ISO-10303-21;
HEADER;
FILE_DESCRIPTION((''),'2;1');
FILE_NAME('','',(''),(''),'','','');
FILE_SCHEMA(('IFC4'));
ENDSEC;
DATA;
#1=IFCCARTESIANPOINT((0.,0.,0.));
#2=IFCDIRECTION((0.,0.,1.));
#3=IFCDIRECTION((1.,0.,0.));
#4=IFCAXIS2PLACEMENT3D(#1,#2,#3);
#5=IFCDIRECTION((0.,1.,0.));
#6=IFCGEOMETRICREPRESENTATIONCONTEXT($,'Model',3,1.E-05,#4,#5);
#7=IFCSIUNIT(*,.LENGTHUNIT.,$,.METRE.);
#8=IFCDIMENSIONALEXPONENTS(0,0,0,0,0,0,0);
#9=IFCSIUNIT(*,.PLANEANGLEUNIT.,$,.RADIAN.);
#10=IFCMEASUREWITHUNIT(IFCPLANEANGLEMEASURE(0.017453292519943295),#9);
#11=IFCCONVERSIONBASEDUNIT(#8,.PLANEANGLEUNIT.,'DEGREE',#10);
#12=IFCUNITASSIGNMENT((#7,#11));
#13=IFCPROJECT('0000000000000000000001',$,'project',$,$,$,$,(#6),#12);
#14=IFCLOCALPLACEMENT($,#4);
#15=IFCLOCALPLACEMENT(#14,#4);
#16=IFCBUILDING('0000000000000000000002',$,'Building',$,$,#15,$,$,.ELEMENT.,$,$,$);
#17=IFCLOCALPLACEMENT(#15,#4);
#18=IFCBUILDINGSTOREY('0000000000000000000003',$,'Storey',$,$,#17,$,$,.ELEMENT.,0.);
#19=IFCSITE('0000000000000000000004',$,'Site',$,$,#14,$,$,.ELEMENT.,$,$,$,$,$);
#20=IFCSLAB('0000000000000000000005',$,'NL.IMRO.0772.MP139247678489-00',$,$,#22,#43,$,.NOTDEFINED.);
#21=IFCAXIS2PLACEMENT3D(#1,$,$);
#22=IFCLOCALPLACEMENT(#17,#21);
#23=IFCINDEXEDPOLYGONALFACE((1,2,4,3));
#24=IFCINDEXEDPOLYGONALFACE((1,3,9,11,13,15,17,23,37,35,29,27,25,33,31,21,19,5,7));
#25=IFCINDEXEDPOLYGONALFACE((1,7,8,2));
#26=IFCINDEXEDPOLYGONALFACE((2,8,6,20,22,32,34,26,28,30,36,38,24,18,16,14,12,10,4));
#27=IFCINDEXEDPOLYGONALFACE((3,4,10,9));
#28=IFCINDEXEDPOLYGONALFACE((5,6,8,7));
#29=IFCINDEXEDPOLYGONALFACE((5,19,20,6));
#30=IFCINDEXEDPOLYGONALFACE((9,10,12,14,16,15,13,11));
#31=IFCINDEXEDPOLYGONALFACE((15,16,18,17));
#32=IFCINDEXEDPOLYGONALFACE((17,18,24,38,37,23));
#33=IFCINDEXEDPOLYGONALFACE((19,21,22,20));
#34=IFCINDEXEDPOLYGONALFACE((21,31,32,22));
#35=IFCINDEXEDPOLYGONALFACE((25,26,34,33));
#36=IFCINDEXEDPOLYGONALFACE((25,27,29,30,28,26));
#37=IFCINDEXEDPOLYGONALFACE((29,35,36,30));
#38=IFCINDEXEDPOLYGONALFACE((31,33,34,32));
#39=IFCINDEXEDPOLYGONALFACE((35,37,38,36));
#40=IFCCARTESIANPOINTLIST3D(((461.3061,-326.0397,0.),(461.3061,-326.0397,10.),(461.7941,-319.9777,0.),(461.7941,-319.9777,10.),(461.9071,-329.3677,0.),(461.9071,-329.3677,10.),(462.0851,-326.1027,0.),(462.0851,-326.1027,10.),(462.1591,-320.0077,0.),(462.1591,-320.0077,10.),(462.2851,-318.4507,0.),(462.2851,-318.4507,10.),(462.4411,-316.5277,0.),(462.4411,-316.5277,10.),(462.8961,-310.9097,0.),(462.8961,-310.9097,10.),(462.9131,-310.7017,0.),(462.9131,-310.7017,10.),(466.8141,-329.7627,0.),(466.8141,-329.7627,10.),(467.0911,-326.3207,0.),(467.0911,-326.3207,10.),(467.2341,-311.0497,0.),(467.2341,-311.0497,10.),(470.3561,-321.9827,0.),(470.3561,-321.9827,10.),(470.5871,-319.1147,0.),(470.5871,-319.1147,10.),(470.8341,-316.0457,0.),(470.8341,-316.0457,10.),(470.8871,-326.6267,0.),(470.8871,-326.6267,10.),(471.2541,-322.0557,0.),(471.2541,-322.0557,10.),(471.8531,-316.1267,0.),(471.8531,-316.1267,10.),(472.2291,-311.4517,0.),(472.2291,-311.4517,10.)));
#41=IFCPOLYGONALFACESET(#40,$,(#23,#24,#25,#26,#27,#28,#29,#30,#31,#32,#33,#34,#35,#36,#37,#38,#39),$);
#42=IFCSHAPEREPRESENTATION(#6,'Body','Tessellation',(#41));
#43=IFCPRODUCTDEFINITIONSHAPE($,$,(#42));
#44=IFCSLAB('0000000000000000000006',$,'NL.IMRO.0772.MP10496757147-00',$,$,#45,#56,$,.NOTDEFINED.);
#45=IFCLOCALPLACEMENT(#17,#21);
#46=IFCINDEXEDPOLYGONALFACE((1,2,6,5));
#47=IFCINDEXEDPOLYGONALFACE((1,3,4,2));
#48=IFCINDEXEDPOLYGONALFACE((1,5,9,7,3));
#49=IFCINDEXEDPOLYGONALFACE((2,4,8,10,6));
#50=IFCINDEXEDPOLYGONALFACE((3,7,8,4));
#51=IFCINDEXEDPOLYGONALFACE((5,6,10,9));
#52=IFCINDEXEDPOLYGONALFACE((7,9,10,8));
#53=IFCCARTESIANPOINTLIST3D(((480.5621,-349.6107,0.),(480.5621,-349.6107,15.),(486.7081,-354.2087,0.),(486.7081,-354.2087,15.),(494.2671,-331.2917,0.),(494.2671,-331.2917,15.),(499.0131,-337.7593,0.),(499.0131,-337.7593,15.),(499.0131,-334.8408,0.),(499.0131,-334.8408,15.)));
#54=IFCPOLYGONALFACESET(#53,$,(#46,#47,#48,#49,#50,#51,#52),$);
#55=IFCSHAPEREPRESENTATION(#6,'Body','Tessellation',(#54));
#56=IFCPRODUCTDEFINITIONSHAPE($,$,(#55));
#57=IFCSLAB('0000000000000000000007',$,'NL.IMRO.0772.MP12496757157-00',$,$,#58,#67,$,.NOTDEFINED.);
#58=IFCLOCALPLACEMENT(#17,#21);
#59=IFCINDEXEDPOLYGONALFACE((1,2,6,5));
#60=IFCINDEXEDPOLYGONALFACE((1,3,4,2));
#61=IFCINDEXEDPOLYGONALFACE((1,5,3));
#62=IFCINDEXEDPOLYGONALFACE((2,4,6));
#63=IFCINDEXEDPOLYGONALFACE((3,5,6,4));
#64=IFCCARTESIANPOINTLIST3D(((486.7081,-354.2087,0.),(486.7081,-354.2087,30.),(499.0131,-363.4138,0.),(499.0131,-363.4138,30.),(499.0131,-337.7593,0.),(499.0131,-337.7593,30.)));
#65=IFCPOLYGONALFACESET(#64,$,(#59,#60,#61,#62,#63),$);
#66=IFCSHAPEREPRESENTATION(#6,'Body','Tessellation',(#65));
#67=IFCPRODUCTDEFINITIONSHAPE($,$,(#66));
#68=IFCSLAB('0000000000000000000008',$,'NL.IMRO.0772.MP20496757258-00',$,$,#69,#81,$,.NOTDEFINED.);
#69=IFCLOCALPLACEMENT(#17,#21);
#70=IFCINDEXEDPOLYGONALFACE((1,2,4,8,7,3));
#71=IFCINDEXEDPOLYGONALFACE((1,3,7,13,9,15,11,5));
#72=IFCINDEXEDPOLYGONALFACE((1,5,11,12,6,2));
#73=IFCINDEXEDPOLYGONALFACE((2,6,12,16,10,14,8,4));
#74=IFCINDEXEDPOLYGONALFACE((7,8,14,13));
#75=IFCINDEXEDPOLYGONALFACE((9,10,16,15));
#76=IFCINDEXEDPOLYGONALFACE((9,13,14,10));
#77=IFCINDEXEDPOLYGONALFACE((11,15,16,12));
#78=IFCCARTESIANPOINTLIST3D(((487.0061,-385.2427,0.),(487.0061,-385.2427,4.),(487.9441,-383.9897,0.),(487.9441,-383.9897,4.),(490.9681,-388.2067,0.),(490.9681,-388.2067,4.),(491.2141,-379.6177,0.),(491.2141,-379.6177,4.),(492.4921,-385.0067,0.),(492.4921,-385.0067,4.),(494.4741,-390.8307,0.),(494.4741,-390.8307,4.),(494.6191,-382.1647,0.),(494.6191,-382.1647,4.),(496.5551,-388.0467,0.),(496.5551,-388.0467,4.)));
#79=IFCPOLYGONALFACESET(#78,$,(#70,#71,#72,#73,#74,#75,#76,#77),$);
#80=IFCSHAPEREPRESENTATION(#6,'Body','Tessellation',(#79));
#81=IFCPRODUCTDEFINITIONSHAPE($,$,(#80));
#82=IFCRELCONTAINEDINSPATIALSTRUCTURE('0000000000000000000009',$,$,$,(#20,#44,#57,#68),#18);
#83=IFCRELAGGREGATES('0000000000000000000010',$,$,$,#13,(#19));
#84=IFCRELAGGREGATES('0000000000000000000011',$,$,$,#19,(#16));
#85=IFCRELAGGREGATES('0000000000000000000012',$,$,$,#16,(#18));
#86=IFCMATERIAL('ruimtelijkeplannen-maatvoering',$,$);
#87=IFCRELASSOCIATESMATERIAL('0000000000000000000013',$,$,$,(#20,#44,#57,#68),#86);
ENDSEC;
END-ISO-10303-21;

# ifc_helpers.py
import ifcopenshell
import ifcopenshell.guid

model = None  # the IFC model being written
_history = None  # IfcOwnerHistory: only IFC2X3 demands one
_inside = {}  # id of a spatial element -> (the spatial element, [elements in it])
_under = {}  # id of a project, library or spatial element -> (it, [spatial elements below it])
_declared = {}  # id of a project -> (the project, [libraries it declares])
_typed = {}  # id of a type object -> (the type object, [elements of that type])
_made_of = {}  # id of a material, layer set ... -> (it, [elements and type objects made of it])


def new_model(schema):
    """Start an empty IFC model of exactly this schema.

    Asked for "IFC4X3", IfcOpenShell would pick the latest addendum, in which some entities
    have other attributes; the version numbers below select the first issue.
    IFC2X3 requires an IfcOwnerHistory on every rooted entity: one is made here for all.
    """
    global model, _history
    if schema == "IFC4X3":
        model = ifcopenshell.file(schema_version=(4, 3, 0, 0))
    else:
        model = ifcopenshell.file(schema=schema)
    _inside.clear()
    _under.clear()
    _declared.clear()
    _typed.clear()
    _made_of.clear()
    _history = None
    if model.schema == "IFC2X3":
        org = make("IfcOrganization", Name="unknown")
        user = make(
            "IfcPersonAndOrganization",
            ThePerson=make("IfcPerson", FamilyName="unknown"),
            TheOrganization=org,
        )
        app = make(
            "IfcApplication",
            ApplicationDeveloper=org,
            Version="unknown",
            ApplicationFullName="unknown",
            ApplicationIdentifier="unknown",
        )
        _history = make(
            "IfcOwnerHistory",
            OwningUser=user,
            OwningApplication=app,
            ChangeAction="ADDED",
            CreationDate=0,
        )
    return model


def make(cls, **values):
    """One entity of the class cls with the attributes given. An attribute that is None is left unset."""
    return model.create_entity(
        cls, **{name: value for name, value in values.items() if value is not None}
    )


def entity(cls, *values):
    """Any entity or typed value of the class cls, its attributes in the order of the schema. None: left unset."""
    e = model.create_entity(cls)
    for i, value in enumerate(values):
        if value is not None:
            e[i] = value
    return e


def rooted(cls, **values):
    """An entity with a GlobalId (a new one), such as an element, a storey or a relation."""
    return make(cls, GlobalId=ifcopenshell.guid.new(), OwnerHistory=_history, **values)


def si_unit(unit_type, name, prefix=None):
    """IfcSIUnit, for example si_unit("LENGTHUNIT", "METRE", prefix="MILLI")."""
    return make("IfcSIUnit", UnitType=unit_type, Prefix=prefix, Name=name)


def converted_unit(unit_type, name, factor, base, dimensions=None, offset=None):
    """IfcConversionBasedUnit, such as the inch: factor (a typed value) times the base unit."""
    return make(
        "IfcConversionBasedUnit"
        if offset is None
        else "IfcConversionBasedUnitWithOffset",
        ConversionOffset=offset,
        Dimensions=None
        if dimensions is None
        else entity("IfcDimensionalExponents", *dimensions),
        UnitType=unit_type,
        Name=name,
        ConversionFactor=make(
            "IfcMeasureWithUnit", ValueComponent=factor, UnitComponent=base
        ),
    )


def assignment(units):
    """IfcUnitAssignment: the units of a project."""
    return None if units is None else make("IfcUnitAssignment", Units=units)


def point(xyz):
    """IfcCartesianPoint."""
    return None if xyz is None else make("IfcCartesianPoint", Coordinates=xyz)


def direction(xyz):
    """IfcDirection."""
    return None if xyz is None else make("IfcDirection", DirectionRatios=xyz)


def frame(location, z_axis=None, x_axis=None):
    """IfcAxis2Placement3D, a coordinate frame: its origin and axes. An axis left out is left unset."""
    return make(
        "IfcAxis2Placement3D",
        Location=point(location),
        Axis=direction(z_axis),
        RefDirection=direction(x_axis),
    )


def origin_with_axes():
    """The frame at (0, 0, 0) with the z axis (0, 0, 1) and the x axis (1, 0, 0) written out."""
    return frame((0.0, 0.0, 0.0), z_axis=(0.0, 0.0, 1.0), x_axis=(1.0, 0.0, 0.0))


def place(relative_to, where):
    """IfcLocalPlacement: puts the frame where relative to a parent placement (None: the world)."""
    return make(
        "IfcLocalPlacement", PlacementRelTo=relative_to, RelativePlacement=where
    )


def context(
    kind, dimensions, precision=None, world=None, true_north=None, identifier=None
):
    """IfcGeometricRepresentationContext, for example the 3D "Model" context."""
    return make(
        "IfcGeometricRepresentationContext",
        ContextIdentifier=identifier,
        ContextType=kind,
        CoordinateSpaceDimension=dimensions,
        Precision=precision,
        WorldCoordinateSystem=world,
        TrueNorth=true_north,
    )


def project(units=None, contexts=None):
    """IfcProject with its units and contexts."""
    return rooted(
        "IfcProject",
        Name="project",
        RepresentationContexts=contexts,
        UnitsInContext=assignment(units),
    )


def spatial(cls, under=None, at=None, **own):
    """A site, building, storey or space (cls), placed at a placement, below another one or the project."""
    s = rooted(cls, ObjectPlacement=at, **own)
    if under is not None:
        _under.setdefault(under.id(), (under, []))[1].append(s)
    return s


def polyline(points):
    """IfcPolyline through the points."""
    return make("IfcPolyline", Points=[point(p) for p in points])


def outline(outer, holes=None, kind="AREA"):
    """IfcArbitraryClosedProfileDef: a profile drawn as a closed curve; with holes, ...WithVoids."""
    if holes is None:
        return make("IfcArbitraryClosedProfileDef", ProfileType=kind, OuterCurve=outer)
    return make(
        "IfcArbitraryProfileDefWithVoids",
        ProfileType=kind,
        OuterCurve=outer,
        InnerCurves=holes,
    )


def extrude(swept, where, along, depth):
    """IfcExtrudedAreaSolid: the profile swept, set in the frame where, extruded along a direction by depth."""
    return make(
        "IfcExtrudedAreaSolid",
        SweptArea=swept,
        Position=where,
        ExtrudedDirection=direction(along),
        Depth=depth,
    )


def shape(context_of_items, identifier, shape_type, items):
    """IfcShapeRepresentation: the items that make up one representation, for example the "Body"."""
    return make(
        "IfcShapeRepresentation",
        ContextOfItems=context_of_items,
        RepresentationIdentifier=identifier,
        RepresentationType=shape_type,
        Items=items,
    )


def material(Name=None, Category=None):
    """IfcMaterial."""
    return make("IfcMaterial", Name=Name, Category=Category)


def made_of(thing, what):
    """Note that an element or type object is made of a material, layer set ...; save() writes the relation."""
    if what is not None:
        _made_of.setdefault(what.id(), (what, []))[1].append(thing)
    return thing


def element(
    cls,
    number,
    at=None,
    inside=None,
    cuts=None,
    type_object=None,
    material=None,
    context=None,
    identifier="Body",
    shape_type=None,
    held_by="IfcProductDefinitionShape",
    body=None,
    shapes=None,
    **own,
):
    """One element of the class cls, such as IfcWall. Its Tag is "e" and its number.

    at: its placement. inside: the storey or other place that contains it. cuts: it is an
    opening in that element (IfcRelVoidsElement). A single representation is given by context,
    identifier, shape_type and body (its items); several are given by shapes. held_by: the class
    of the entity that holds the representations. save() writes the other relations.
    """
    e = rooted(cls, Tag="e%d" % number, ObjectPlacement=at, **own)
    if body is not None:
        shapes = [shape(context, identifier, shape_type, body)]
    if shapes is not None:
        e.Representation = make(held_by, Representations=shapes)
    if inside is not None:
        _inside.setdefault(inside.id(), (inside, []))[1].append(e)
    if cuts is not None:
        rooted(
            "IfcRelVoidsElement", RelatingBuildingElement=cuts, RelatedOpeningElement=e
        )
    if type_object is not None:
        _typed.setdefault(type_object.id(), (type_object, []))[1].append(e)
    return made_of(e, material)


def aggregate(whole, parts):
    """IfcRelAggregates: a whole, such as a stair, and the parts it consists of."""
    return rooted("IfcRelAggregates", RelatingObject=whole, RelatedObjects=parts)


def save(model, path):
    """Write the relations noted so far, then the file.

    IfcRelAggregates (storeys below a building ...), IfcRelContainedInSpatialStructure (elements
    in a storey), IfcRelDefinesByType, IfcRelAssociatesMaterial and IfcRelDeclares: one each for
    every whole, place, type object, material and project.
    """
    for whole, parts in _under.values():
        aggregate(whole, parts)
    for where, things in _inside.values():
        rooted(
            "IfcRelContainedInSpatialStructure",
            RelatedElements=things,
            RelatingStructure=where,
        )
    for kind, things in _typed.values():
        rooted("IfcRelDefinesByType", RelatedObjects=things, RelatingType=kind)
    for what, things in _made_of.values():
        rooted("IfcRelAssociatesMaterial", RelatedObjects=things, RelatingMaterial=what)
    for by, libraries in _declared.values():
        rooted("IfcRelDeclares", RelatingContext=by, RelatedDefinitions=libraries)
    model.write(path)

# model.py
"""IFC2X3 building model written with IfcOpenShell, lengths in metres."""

from ifc_helpers import new_model, entity, si_unit, converted_unit, direction, origin_with_axes, place, context, project, spatial, polyline, outline, extrude, material, element, save


model = new_model("IFC2X3")

# Units and contexts
model_context = context("Model", 3, precision=1e-05, world=origin_with_axes(), true_north=direction((0.0, 1.0, 0.0)))
ifc_project = project(units=[si_unit("LENGTHUNIT", "METRE"), converted_unit("PLANEANGLEUNIT", "DEGREE", entity("IfcPlaneAngleMeasure", 0.017453292519943295), si_unit("PLANEANGLEUNIT", "RADIAN"), dimensions=[0, 0, 0, 0, 0, 0, 0])], contexts=[model_context])

# Site, building, storey
site_placement = place(None, origin_with_axes())
site = spatial("IfcSite", under=ifc_project, at=site_placement, Name="Site", CompositionType="ELEMENT")
building_placement = place(site_placement, origin_with_axes())
building = spatial("IfcBuilding", under=site, at=building_placement, Name="Building", CompositionType="ELEMENT")
storey_placement = place(building_placement, origin_with_axes())
storey = spatial("IfcBuildingStorey", under=building, at=storey_placement, Name="Storey", CompositionType="ELEMENT", Elevation=0.0)

# Slabs
ifc_material = material(Name="ruimtelijkeplannen-maatvoering")
slab_1_placement = place(storey_placement, origin_with_axes())
element("IfcSlab", 1, at=slab_1_placement, inside=storey, material=ifc_material, Name="NL.IMRO.0772.MP139247678489-00", PredefinedType="NOTDEFINED", context=model_context, shape_type="SweptSolid", body=[
    extrude(outline(polyline([(462.1591, -320.0077), (462.2851, -318.4507), (462.4411, -316.5277), (462.8961, -310.9097), (462.9131, -310.7017), (467.2341, -311.0497), (472.2291, -311.4517), (471.8531, -316.1267), (470.8341, -316.0457), (470.5871, -319.1147), (470.3561, -321.9827), (471.2541, -322.0557), (470.8871, -326.6267), (467.0911, -326.3207), (466.8141, -329.7627), (461.9071, -329.3677), (462.0851, -326.1027), (461.3061, -326.0397), (461.7941, -319.9777), (462.1591, -320.0077)])), origin_with_axes(), (0.0, 0.0, 1.0), 10.0),
])
slab_2_placement = place(storey_placement, origin_with_axes())
element("IfcSlab", 2, at=slab_2_placement, inside=storey, material=ifc_material, Name="NL.IMRO.0772.MP10496757147-00", PredefinedType="NOTDEFINED", context=model_context, shape_type="SweptSolid", body=[
    extrude(outline(polyline([(486.7081, -354.2087), (480.5621, -349.6107), (494.2671, -331.2917), (499.0131, -334.8408), (499.0131, -337.7593), (486.7081, -354.2087)])), origin_with_axes(), (0.0, 0.0, 1.0), 15.0),
])
slab_3_placement = place(storey_placement, origin_with_axes())
element("IfcSlab", 3, at=slab_3_placement, inside=storey, material=ifc_material, Name="NL.IMRO.0772.MP12496757157-00", PredefinedType="NOTDEFINED", context=model_context, shape_type="SweptSolid", body=[
    extrude(outline(polyline([(486.7081, -354.2087), (499.0131, -337.7593), (499.0131, -363.4138), (486.7081, -354.2087)])), origin_with_axes(), (0.0, 0.0, 1.0), 30.0),
])
slab_4_placement = place(storey_placement, origin_with_axes())
element("IfcSlab", 4, at=slab_4_placement, inside=storey, material=ifc_material, Name="NL.IMRO.0772.MP20496757258-00", PredefinedType="NOTDEFINED", context=model_context, shape_type="SweptSolid", body=[
    extrude(outline(polyline([(490.9681, -388.2067), (487.0061, -385.2427), (487.9441, -383.9897), (491.2141, -379.6177), (494.6191, -382.1647), (492.4921, -385.0067), (496.5551, -388.0467), (494.4741, -390.8307), (490.9681, -388.2067)])), origin_with_axes(), (0.0, 0.0, 1.0), 4.0),
])

save(model, "model.ifc")
